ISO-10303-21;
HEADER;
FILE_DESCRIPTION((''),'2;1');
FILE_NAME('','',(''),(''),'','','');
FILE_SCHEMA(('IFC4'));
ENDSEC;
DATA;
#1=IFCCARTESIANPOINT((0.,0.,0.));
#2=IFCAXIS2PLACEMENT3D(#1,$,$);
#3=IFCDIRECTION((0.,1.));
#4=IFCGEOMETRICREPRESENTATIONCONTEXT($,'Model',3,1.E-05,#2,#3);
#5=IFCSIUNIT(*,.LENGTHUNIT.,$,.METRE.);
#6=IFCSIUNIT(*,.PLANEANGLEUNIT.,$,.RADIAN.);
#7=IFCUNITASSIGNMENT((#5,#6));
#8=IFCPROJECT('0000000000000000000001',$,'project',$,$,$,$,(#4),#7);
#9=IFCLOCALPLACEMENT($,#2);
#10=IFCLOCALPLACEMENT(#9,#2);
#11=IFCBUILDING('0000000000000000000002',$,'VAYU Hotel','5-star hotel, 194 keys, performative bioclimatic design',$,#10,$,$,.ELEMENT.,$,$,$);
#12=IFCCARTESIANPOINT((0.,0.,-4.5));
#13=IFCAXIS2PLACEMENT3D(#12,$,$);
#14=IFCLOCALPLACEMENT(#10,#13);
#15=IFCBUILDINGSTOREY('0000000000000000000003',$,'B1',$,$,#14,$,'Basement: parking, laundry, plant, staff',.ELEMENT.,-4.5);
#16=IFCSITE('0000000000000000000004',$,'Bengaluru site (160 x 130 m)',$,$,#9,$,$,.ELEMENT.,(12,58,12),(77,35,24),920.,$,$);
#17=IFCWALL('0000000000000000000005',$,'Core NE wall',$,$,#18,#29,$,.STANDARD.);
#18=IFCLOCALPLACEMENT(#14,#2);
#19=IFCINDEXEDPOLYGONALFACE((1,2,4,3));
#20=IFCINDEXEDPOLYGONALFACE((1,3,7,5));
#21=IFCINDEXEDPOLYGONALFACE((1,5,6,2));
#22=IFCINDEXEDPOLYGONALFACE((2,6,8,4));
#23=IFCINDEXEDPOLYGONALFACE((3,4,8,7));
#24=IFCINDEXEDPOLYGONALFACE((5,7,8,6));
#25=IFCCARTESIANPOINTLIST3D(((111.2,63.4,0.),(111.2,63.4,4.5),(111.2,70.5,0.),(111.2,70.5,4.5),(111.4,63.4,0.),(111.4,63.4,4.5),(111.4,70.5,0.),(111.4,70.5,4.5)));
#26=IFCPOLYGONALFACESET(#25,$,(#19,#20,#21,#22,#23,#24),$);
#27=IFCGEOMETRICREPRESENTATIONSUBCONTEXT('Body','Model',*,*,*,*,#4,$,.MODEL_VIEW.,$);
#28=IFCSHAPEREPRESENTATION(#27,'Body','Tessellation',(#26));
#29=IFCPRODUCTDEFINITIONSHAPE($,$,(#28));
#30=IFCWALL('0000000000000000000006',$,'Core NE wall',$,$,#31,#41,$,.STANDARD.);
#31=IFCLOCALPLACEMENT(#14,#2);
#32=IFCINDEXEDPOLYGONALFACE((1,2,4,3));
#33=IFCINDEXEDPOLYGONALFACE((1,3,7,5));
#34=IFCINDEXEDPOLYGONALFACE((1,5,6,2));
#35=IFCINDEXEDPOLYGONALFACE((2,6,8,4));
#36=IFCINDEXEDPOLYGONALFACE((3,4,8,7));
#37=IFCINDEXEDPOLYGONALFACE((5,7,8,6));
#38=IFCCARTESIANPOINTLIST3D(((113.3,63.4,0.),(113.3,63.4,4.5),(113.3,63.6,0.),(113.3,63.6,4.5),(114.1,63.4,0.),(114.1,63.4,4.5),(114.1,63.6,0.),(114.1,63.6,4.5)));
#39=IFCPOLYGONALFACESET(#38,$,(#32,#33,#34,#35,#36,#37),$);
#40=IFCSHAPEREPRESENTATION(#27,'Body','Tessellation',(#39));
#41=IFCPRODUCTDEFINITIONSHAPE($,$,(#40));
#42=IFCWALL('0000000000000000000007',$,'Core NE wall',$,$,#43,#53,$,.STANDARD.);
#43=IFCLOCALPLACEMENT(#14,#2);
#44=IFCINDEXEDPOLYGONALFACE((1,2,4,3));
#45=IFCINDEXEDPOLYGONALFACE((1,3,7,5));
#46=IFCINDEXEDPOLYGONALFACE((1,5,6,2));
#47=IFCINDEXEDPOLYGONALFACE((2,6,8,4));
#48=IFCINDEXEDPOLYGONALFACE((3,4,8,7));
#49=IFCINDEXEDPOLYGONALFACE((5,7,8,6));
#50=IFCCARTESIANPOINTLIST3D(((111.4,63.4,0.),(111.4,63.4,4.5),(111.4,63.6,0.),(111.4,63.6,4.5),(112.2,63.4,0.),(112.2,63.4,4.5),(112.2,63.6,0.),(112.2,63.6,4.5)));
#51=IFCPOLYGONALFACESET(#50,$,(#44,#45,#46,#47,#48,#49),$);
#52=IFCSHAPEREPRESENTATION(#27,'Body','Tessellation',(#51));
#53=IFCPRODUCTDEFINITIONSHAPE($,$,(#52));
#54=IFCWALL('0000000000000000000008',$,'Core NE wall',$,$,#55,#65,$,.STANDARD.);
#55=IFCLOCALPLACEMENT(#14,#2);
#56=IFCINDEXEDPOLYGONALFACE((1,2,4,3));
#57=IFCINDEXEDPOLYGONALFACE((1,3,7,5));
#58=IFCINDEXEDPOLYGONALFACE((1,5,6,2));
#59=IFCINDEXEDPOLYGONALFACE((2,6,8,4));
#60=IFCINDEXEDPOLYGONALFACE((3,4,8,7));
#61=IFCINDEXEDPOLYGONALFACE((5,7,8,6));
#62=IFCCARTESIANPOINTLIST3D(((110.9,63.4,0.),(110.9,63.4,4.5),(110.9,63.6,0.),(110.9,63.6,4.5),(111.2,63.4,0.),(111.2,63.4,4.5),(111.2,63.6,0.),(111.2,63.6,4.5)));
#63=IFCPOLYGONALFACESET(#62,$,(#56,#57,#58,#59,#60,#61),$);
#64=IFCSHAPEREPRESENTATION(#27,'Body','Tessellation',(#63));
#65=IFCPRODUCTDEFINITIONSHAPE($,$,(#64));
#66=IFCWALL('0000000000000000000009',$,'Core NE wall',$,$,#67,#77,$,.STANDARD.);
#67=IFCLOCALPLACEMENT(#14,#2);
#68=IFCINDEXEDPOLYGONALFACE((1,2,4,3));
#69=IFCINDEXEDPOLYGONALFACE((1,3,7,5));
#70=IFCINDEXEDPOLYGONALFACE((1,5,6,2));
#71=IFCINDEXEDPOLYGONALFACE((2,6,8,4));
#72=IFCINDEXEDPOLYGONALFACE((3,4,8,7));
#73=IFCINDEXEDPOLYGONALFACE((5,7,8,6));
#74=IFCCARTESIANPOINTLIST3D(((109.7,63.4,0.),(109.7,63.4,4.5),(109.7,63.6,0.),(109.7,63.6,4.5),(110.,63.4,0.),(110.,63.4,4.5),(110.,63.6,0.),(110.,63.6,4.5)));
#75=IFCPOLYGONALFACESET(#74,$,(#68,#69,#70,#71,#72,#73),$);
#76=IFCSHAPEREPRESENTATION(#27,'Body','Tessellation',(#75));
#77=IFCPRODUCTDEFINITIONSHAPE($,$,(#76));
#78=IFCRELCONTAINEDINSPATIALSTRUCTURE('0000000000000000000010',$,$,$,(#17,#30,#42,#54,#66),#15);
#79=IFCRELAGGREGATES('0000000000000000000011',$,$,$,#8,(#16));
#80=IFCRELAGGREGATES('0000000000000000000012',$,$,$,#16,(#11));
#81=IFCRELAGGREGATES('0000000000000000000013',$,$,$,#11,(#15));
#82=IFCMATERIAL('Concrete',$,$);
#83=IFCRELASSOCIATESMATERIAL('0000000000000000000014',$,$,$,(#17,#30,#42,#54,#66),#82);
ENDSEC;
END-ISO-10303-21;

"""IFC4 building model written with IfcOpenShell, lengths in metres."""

from ifc_helpers import new_model, si_unit, direction, frame, origin, place, context, subcontext, project, spatial, polyline, outline, extrude, material, element, save


model = new_model("IFC4")

# Units and contexts
model_context = context("Model", 3, precision=1e-05, world=origin(), true_north=direction((0.0, 1.0)))
body_context = subcontext(model_context, "Body", "Model", "MODEL_VIEW")
ifc_project = project(units=[si_unit("LENGTHUNIT", "METRE"), si_unit("PLANEANGLEUNIT", "RADIAN")], contexts=[model_context])

# Site, building, storey
site_placement = place(None, origin())
site = spatial("IfcSite", under=ifc_project, at=site_placement, Name="Bengaluru site (160 x 130 m)", CompositionType="ELEMENT", RefLatitude=(12, 58, 12), RefLongitude=(77, 35, 24), RefElevation=920.0)
building_placement = place(site_placement, origin())
building = spatial("IfcBuilding", under=site, at=building_placement, Name="VAYU Hotel", Description="5-star hotel, 194 keys, performative bioclimatic design", CompositionType="ELEMENT")
storey_placement = place(building_placement, frame((0.0, 0.0, -4.5)))
storey = spatial("IfcBuildingStorey", under=building, at=storey_placement, Name="B1", LongName="Basement: parking, laundry, plant, staff", CompositionType="ELEMENT", Elevation=-4.5)

# Shared definitions
ifc_material = material(Name="Concrete")

# Walls
wall_1_placement = place(storey_placement, origin())
element("IfcWall", 1, at=wall_1_placement, inside=storey, material=ifc_material, Name="Core NE wall", PredefinedType="STANDARD", context=body_context, shape_type="SweptSolid", body=[
    extrude(outline(polyline([(111.2, 63.4), (111.2, 70.5), (111.4, 70.5), (111.4, 63.4), (111.2, 63.4)])), origin(), (0.0, 0.0, 1.0), 4.5),
])
wall_2_placement = place(storey_placement, origin())
element("IfcWall", 2, at=wall_2_placement, inside=storey, material=ifc_material, Name="Core NE wall", PredefinedType="STANDARD", context=body_context, shape_type="SweptSolid", body=[
    extrude(outline(polyline([(113.3, 63.6), (114.1, 63.6), (114.1, 63.4), (113.3, 63.4), (113.3, 63.6)])), origin(), (0.0, 0.0, 1.0), 4.5),
])
wall_3_placement = place(storey_placement, origin())
element("IfcWall", 3, at=wall_3_placement, inside=storey, material=ifc_material, Name="Core NE wall", PredefinedType="STANDARD", context=body_context, shape_type="SweptSolid", body=[
    extrude(outline(polyline([(111.4, 63.6), (112.2, 63.6), (112.2, 63.4), (111.4, 63.4), (111.4, 63.6)])), origin(), (0.0, 0.0, 1.0), 4.5),
])
wall_4_placement = place(storey_placement, origin())
element("IfcWall", 4, at=wall_4_placement, inside=storey, material=ifc_material, Name="Core NE wall", PredefinedType="STANDARD", context=body_context, shape_type="SweptSolid", body=[
    extrude(outline(polyline([(110.9, 63.6), (111.2, 63.6), (111.2, 63.4), (110.9, 63.4), (110.9, 63.6)])), origin(), (0.0, 0.0, 1.0), 4.5),
])
wall_5_placement = place(storey_placement, origin())
element("IfcWall", 5, at=wall_5_placement, inside=storey, material=ifc_material, Name="Core NE wall", PredefinedType="STANDARD", context=body_context, shape_type="SweptSolid", body=[
    extrude(outline(polyline([(109.7, 63.6), (110.0, 63.6), (110.0, 63.4), (109.7, 63.4), (109.7, 63.6)])), origin(), (0.0, 0.0, 1.0), 4.5),
])

save(model, "model.ifc")
